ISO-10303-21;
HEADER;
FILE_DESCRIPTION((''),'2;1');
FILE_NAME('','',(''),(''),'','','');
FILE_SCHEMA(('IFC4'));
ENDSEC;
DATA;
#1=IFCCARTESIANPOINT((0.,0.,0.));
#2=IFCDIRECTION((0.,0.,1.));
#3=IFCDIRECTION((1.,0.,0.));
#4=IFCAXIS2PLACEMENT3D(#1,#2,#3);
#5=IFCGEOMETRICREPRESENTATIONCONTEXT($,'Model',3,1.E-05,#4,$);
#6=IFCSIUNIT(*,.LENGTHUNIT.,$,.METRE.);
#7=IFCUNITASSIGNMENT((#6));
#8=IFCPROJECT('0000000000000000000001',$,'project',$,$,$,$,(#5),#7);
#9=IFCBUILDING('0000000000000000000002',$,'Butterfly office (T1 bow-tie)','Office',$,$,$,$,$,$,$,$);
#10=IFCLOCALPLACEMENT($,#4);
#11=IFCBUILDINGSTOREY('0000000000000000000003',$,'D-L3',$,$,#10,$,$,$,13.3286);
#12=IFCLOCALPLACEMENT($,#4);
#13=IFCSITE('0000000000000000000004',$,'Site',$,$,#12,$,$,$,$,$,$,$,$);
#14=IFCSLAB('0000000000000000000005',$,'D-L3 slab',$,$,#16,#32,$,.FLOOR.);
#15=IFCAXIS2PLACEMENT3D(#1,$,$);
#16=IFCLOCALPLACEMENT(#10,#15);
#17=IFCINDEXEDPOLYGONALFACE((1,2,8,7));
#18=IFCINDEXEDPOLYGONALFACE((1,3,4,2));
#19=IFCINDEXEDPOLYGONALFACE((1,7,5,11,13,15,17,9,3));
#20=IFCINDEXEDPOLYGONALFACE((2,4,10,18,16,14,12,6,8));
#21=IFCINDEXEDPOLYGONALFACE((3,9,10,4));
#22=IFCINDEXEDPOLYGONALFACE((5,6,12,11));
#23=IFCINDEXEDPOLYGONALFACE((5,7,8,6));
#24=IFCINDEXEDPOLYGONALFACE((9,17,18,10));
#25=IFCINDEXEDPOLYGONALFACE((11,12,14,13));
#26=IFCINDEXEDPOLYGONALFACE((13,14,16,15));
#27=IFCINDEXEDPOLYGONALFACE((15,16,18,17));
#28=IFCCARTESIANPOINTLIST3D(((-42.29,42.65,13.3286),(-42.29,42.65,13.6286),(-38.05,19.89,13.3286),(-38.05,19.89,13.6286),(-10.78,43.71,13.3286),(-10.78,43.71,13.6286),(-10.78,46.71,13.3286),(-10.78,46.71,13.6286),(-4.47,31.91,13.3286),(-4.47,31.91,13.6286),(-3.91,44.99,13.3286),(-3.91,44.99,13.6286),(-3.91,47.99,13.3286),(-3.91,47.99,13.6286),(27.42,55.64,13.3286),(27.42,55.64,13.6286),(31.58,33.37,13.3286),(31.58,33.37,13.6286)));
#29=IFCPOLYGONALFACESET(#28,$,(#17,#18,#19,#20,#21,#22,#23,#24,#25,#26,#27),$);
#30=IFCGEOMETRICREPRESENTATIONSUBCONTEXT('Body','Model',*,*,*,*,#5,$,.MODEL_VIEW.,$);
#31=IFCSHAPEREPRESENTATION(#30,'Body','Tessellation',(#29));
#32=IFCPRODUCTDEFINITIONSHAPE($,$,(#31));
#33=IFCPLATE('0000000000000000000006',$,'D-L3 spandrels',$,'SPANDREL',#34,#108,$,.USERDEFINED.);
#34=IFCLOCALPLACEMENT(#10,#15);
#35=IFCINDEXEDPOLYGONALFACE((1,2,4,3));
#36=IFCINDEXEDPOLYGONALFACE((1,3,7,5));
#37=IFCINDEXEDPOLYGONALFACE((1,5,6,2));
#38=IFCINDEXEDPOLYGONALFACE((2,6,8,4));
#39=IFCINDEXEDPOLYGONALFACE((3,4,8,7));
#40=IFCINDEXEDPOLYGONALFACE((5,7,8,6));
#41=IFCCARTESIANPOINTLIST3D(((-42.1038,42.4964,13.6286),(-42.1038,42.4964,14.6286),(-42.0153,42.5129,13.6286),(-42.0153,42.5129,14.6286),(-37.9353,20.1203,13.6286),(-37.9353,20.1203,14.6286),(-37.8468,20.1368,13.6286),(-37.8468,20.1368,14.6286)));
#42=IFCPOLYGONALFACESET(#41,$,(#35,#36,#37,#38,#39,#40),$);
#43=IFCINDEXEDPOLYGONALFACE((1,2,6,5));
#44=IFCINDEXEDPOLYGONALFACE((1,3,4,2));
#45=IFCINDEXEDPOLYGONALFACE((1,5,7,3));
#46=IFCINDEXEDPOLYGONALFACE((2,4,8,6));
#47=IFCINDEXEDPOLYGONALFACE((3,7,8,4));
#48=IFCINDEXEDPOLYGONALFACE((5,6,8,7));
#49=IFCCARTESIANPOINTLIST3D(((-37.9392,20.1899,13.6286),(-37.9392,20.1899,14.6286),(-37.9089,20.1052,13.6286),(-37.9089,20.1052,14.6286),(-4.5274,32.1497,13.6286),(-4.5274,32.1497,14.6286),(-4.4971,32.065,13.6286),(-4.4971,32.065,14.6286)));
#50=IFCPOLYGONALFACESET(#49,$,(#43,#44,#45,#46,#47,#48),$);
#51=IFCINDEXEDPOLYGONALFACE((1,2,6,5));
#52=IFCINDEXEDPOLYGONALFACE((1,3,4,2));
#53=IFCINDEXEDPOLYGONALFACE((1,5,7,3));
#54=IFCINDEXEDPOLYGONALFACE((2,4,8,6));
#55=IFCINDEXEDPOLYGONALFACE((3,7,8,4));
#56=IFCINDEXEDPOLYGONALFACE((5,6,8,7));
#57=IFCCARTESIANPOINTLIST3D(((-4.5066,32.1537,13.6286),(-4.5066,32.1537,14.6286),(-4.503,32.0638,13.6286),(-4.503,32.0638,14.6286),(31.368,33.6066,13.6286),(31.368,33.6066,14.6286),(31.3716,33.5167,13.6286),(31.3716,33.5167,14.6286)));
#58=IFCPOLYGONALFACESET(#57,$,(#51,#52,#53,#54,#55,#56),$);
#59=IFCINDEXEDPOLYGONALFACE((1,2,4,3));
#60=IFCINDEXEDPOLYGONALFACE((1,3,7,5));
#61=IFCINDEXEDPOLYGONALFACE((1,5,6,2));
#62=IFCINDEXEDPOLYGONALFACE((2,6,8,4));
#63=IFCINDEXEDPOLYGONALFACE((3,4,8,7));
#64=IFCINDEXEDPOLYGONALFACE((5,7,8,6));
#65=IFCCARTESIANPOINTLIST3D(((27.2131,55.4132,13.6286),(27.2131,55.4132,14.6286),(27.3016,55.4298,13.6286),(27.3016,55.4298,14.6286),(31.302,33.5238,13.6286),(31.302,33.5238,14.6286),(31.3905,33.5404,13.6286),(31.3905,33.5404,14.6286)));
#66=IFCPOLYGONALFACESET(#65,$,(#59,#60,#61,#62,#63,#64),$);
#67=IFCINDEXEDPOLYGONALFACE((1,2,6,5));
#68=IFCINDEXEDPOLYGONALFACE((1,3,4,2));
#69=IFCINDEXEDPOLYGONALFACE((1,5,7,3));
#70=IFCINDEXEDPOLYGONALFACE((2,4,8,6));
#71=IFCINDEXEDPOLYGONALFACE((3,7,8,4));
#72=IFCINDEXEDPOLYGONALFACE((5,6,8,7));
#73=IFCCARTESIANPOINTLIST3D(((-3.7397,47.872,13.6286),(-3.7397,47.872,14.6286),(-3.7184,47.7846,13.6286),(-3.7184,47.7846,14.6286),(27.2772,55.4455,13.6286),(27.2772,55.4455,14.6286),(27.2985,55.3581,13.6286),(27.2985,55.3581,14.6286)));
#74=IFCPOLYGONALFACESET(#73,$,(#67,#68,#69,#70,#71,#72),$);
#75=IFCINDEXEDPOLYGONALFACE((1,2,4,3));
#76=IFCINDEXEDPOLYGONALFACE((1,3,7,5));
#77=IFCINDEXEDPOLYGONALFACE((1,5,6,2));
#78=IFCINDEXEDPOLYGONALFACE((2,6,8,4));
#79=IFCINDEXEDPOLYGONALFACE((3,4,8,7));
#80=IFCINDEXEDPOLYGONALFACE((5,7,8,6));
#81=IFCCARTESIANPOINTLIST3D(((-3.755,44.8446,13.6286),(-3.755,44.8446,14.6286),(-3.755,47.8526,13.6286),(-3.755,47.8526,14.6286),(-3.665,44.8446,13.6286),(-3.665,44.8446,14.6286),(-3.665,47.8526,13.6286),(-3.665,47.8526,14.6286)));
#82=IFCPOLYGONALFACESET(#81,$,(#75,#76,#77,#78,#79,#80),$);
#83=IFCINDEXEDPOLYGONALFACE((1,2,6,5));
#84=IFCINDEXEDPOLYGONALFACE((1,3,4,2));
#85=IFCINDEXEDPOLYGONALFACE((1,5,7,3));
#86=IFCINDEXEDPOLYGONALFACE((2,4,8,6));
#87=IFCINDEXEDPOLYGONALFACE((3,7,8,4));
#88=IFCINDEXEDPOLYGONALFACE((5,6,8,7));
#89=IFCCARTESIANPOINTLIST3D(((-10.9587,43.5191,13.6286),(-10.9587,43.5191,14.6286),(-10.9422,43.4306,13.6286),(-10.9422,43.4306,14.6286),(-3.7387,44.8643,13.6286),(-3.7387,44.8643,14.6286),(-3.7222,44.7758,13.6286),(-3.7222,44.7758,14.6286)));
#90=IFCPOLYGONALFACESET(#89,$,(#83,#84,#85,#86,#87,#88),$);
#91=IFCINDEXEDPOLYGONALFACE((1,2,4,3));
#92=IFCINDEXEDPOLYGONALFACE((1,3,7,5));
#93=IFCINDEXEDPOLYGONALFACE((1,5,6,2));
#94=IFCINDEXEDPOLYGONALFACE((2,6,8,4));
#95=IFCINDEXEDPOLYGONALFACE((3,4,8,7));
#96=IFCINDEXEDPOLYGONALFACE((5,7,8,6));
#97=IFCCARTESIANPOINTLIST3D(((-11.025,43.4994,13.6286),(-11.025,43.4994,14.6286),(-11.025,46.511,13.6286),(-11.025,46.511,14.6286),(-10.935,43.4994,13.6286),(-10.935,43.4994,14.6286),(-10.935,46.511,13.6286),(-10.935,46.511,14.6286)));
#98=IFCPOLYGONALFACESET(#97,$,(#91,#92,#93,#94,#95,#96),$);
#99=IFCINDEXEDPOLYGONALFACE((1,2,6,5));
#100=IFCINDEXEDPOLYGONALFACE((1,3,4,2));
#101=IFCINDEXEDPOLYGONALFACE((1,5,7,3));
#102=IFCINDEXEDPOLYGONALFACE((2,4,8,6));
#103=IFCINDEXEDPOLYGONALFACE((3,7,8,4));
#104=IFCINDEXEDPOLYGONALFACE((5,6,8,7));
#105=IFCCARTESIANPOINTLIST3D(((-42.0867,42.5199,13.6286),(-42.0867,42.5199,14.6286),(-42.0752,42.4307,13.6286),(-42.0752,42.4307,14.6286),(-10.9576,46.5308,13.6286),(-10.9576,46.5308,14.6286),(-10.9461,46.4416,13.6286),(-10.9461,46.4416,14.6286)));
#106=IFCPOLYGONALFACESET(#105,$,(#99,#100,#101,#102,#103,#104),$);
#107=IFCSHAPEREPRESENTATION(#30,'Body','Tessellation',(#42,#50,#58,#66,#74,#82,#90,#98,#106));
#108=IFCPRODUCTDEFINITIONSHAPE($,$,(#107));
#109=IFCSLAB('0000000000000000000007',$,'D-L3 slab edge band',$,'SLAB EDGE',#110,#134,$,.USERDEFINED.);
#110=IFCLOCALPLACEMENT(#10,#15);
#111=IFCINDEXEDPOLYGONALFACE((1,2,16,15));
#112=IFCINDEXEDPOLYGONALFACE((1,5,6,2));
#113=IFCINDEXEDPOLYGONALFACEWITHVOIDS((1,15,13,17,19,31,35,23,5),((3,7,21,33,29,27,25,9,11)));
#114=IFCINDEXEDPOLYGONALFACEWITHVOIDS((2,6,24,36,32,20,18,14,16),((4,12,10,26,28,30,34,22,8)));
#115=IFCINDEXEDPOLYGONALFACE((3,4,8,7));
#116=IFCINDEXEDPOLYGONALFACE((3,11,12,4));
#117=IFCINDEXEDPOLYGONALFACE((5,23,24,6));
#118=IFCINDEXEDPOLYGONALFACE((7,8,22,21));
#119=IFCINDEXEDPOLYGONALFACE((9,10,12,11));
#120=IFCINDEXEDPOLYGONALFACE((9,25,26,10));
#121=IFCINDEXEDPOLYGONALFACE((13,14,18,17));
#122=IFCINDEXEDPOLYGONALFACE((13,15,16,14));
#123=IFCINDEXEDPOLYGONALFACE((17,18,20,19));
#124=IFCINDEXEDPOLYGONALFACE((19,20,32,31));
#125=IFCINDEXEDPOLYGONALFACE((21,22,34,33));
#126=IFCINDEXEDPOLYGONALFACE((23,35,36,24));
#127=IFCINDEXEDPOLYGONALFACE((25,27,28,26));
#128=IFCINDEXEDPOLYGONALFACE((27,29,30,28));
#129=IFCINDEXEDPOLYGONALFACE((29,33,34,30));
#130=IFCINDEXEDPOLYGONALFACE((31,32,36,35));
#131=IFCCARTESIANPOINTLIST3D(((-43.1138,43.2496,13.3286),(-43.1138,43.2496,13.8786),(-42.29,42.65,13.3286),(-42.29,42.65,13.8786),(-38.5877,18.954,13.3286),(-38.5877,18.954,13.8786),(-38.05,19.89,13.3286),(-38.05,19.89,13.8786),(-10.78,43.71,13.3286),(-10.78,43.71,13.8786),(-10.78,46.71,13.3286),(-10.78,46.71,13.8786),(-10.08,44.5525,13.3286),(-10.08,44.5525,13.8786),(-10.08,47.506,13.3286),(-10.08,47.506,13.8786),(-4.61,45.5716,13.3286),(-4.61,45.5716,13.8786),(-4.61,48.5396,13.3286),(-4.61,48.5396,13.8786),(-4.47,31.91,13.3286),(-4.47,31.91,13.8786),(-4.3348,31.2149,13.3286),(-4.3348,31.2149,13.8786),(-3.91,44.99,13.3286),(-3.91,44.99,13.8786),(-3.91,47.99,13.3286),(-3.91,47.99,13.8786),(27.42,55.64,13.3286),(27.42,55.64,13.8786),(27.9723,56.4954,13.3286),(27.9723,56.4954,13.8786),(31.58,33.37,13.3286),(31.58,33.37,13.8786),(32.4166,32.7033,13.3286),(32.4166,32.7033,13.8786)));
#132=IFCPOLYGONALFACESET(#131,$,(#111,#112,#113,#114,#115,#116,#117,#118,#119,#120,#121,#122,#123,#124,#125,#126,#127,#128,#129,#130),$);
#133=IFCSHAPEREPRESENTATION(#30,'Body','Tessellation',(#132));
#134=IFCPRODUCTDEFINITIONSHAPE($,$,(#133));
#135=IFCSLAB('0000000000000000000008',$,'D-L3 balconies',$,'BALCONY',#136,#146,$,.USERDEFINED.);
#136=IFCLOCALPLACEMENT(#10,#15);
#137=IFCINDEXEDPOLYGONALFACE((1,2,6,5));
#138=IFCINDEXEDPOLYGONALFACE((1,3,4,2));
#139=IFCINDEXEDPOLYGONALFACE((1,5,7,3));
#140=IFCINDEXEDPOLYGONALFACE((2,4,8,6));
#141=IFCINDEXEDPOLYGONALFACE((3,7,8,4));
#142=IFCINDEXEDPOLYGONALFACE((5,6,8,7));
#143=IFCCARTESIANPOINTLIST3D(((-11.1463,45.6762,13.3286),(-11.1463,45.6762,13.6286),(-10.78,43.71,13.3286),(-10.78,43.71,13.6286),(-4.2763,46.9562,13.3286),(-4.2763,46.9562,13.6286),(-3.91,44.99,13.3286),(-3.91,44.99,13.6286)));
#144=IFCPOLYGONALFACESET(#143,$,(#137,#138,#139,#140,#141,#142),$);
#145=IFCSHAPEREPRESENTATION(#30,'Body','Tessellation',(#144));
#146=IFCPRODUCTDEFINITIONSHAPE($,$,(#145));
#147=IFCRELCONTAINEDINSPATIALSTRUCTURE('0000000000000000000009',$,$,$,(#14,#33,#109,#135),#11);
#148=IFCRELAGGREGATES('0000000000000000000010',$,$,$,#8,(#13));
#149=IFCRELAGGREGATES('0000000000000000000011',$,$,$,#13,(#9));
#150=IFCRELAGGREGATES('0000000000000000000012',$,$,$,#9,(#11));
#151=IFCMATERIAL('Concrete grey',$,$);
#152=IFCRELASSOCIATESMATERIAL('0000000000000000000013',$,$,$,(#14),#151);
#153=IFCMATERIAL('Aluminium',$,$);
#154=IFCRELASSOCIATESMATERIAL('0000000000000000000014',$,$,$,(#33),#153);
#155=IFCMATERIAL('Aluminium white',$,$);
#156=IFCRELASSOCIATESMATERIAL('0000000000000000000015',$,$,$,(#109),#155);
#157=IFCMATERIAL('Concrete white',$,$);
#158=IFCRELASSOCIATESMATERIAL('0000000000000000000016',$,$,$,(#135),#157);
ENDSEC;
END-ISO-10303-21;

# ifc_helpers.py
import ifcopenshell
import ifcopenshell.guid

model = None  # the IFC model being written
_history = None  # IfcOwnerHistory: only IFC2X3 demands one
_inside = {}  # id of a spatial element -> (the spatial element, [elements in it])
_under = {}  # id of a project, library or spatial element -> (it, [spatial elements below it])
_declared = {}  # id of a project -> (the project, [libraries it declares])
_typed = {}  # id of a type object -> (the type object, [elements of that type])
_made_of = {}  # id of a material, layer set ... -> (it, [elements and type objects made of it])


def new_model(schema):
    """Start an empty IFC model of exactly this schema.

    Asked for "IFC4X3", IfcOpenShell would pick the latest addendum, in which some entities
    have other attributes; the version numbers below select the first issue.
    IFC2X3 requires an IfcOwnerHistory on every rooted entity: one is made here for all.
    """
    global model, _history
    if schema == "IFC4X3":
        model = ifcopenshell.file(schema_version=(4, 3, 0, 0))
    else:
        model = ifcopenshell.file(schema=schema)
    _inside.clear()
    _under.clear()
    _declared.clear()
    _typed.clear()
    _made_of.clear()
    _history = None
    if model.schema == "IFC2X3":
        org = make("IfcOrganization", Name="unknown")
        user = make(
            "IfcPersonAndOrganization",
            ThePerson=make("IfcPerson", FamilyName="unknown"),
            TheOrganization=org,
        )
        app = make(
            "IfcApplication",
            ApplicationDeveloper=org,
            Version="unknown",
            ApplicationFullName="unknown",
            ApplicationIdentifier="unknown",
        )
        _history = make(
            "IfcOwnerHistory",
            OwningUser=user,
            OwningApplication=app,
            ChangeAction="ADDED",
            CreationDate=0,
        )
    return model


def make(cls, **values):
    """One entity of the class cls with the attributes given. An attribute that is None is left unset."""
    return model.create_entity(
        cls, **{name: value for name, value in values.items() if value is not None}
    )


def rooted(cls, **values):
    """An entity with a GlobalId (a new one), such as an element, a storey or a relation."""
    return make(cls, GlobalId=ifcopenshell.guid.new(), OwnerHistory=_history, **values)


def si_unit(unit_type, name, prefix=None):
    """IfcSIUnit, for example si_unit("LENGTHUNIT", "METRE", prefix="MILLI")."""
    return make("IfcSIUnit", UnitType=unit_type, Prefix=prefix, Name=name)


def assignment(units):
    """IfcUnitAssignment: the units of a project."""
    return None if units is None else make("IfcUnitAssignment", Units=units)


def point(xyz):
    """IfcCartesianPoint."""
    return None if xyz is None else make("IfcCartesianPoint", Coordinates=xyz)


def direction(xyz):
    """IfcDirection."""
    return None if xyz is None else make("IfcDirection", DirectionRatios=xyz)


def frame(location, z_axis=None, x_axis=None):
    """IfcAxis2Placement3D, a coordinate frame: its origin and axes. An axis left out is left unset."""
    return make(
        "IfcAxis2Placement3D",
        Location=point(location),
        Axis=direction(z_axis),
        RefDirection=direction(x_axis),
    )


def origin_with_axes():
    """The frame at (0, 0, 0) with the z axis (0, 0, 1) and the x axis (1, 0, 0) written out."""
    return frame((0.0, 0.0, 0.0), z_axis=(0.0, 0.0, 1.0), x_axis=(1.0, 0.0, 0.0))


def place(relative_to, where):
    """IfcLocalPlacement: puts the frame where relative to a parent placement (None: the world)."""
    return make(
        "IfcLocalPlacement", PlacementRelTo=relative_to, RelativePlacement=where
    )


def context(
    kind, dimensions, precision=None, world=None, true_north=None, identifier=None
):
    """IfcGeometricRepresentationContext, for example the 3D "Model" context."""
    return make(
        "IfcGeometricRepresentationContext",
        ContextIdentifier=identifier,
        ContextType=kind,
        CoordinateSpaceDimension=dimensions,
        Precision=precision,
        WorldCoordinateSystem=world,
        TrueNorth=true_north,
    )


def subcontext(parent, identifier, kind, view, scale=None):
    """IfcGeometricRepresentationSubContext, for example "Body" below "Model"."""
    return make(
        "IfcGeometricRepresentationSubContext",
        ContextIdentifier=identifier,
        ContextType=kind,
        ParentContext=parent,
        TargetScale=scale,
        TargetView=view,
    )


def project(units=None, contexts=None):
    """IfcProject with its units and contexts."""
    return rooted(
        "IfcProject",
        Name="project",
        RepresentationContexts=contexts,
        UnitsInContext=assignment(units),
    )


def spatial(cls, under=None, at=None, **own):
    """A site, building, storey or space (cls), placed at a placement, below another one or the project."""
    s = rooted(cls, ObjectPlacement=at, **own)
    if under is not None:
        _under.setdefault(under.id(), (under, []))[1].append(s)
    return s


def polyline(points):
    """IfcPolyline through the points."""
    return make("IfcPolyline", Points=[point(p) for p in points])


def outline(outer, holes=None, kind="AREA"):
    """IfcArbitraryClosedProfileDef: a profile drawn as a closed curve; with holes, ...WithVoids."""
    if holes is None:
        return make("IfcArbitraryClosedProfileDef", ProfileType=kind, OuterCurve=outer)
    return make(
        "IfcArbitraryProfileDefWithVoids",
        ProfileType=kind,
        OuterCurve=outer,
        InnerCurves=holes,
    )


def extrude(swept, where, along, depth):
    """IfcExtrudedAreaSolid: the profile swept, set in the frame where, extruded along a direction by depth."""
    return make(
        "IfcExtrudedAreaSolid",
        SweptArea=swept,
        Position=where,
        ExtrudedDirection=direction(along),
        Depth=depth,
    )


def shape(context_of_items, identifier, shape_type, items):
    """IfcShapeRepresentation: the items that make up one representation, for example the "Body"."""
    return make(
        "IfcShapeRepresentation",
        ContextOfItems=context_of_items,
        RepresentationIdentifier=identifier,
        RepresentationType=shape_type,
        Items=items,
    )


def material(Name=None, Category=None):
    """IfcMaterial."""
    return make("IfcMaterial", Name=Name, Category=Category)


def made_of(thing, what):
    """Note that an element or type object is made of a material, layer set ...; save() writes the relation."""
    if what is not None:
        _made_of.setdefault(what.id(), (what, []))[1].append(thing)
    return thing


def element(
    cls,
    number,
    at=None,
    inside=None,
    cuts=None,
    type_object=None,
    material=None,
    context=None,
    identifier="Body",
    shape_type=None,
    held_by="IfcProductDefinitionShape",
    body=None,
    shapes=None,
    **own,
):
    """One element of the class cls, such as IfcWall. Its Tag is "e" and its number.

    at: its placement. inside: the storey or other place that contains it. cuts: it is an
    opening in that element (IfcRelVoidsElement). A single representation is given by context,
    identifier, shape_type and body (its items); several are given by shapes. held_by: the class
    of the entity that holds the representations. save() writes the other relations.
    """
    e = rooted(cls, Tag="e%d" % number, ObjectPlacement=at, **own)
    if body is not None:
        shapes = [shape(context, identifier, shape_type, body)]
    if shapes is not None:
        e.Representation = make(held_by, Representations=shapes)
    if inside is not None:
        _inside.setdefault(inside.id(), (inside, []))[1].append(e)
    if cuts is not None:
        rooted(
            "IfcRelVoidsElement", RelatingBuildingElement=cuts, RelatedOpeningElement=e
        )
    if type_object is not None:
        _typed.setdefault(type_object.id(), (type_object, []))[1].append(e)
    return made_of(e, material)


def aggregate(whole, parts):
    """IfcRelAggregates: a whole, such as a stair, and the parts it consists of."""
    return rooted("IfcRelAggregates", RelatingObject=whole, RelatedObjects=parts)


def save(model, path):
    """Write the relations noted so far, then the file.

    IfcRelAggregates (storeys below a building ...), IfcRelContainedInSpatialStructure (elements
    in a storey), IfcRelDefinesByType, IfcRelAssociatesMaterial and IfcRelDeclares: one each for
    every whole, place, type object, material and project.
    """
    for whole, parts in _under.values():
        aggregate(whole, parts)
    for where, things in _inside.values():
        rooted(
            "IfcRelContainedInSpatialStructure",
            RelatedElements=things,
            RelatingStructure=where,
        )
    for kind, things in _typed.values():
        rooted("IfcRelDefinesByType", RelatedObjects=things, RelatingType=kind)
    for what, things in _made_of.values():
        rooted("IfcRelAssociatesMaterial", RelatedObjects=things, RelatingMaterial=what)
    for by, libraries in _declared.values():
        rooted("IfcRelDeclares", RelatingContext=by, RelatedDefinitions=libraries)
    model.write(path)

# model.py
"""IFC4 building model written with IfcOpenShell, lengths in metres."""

from ifc_helpers import new_model, si_unit, frame, origin_with_axes, place, context, subcontext, project, spatial, polyline, outline, extrude, material, element, save


model = new_model("IFC4")

# Units and contexts
model_context = context("Model", 3, precision=1e-05, world=origin_with_axes())
body_context = subcontext(model_context, "Body", "Model", "MODEL_VIEW")
ifc_project = project(units=[si_unit("LENGTHUNIT", "METRE")], contexts=[model_context])

# Site, building, storey
site_placement = place(None, origin_with_axes())
site = spatial("IfcSite", under=ifc_project, at=site_placement, Name="Site")
building = spatial("IfcBuilding", under=site, Name="Butterfly office (T1 bow-tie)", Description="Office")
storey_placement = place(None, origin_with_axes())
storey = spatial("IfcBuildingStorey", under=building, at=storey_placement, Name="D-L3", Elevation=13.3286)

# Shared definitions
ifc_material_1 = material(Name="Aluminium")

# Slab
ifc_material_2 = material(Name="Concrete grey")
slab_1_placement = place(storey_placement, origin_with_axes())
element("IfcSlab", 1, at=slab_1_placement, inside=storey, material=ifc_material_2, Name="D-L3 slab", PredefinedType="FLOOR", context=body_context, shape_type="SweptSolid", body=[
    extrude(outline(polyline([(-42.29, 42.65), (-38.05, 19.89), (-4.47, 31.91), (31.58, 33.37), (27.42, 55.64), (-3.91, 47.99), (-3.91, 44.99), (-10.78, 43.71), (-10.78, 46.71), (-42.29, 42.65)])), frame((0.0, 0.0, 13.3286), z_axis=(0.0, 0.0, 1.0), x_axis=(1.0, 0.0, 0.0)), (0.0, 0.0, 1.0), 0.3),
])

# Plate
plate_placement = place(storey_placement, origin_with_axes())
element("IfcPlate", 2, at=plate_placement, inside=storey, material=ifc_material_1, Name="D-L3 spandrels", ObjectType="SPANDREL", PredefinedType="USERDEFINED", context=body_context, shape_type="SweptSolid", body=[
    extrude(outline(polyline([(-42.1038, 42.4964), (-37.9353, 20.1203), (-37.8468, 20.1368), (-42.0153, 42.5129), (-42.1038, 42.4964)])), frame((0.0, 0.0, 13.6286), z_axis=(0.0, 0.0, 1.0), x_axis=(1.0, 0.0, 0.0)), (0.0, 0.0, 1.0), 1.0),
    extrude(outline(polyline([(-37.9089, 20.1052), (-4.4971, 32.065), (-4.5274, 32.1497), (-37.9392, 20.1899), (-37.9089, 20.1052)])), frame((0.0, 0.0, 13.6286), z_axis=(0.0, 0.0, 1.0), x_axis=(1.0, 0.0, 0.0)), (0.0, 0.0, 1.0), 1.0),
    extrude(outline(polyline([(-4.503, 32.0638), (31.3716, 33.5167), (31.368, 33.6066), (-4.5066, 32.1537), (-4.503, 32.0638)])), frame((0.0, 0.0, 13.6286), z_axis=(0.0, 0.0, 1.0), x_axis=(1.0, 0.0, 0.0)), (0.0, 0.0, 1.0), 1.0),
    extrude(outline(polyline([(31.3905, 33.5404), (27.3016, 55.4298), (27.2131, 55.4132), (31.302, 33.5238), (31.3905, 33.5404)])), frame((0.0, 0.0, 13.6286), z_axis=(0.0, 0.0, 1.0), x_axis=(1.0, 0.0, 0.0)), (0.0, 0.0, 1.0), 1.0),
    extrude(outline(polyline([(27.2772, 55.4455), (-3.7397, 47.872), (-3.7184, 47.7846), (27.2985, 55.3581), (27.2772, 55.4455)])), frame((0.0, 0.0, 13.6286), z_axis=(0.0, 0.0, 1.0), x_axis=(1.0, 0.0, 0.0)), (0.0, 0.0, 1.0), 1.0),
    extrude(outline(polyline([(-3.755, 47.8526), (-3.755, 44.8446), (-3.665, 44.8446), (-3.665, 47.8526), (-3.755, 47.8526)])), frame((0.0, 0.0, 13.6286), z_axis=(0.0, 0.0, 1.0), x_axis=(1.0, 0.0, 0.0)), (0.0, 0.0, 1.0), 1.0),
    extrude(outline(polyline([(-3.7387, 44.8643), (-10.9587, 43.5191), (-10.9422, 43.4306), (-3.7222, 44.7758), (-3.7387, 44.8643)])), frame((0.0, 0.0, 13.6286), z_axis=(0.0, 0.0, 1.0), x_axis=(1.0, 0.0, 0.0)), (0.0, 0.0, 1.0), 1.0),
    extrude(outline(polyline([(-10.935, 43.4994), (-10.935, 46.511), (-11.025, 46.511), (-11.025, 43.4994), (-10.935, 43.4994)])), frame((0.0, 0.0, 13.6286), z_axis=(0.0, 0.0, 1.0), x_axis=(1.0, 0.0, 0.0)), (0.0, 0.0, 1.0), 1.0),
    extrude(outline(polyline([(-10.9576, 46.5308), (-42.0867, 42.5199), (-42.0752, 42.4307), (-10.9461, 46.4416), (-10.9576, 46.5308)])), frame((0.0, 0.0, 13.6286), z_axis=(0.0, 0.0, 1.0), x_axis=(1.0, 0.0, 0.0)), (0.0, 0.0, 1.0), 1.0),
])

# Slabs
ifc_material_3 = material(Name="Aluminium white")
slab_2_placement = place(storey_placement, origin_with_axes())
element("IfcSlab", 3, at=slab_2_placement, inside=storey, material=ifc_material_3, Name="D-L3 slab edge band", ObjectType="SLAB EDGE", PredefinedType="USERDEFINED", context=body_context, shape_type="SweptSolid", body=[
    extrude(outline(polyline([(-43.1138, 43.2496), (-38.5877, 18.954), (-4.3348, 31.2149), (32.4166, 32.7033), (27.9723, 56.4954), (-4.61, 48.5396), (-4.61, 45.5716), (-10.08, 44.5525), (-10.08, 47.506), (-43.1138, 43.2496)]), holes=[polyline([(-42.29, 42.65), (-38.05, 19.89), (-4.47, 31.91), (31.58, 33.37), (27.42, 55.64), (-3.91, 47.99), (-3.91, 44.99), (-10.78, 43.71), (-10.78, 46.71), (-42.29, 42.65)])]), frame((0.0, 0.0, 13.3286), z_axis=(0.0, 0.0, 1.0), x_axis=(1.0, 0.0, 0.0)), (0.0, 0.0, 1.0), 0.55),
])
ifc_material_4 = material(Name="Concrete white")
slab_3_placement = place(storey_placement, origin_with_axes())
element("IfcSlab", 4, at=slab_3_placement, inside=storey, material=ifc_material_4, Name="D-L3 balconies", ObjectType="BALCONY", PredefinedType="USERDEFINED", context=body_context, shape_type="SweptSolid", body=[
    extrude(outline(polyline([(-3.91, 44.99), (-10.78, 43.71), (-11.1463, 45.6762), (-4.2763, 46.9562), (-3.91, 44.99)])), frame((0.0, 0.0, 13.3286), z_axis=(0.0, 0.0, 1.0), x_axis=(1.0, 0.0, 0.0)), (0.0, 0.0, 1.0), 0.3),
])

save(model, "model.ifc")
